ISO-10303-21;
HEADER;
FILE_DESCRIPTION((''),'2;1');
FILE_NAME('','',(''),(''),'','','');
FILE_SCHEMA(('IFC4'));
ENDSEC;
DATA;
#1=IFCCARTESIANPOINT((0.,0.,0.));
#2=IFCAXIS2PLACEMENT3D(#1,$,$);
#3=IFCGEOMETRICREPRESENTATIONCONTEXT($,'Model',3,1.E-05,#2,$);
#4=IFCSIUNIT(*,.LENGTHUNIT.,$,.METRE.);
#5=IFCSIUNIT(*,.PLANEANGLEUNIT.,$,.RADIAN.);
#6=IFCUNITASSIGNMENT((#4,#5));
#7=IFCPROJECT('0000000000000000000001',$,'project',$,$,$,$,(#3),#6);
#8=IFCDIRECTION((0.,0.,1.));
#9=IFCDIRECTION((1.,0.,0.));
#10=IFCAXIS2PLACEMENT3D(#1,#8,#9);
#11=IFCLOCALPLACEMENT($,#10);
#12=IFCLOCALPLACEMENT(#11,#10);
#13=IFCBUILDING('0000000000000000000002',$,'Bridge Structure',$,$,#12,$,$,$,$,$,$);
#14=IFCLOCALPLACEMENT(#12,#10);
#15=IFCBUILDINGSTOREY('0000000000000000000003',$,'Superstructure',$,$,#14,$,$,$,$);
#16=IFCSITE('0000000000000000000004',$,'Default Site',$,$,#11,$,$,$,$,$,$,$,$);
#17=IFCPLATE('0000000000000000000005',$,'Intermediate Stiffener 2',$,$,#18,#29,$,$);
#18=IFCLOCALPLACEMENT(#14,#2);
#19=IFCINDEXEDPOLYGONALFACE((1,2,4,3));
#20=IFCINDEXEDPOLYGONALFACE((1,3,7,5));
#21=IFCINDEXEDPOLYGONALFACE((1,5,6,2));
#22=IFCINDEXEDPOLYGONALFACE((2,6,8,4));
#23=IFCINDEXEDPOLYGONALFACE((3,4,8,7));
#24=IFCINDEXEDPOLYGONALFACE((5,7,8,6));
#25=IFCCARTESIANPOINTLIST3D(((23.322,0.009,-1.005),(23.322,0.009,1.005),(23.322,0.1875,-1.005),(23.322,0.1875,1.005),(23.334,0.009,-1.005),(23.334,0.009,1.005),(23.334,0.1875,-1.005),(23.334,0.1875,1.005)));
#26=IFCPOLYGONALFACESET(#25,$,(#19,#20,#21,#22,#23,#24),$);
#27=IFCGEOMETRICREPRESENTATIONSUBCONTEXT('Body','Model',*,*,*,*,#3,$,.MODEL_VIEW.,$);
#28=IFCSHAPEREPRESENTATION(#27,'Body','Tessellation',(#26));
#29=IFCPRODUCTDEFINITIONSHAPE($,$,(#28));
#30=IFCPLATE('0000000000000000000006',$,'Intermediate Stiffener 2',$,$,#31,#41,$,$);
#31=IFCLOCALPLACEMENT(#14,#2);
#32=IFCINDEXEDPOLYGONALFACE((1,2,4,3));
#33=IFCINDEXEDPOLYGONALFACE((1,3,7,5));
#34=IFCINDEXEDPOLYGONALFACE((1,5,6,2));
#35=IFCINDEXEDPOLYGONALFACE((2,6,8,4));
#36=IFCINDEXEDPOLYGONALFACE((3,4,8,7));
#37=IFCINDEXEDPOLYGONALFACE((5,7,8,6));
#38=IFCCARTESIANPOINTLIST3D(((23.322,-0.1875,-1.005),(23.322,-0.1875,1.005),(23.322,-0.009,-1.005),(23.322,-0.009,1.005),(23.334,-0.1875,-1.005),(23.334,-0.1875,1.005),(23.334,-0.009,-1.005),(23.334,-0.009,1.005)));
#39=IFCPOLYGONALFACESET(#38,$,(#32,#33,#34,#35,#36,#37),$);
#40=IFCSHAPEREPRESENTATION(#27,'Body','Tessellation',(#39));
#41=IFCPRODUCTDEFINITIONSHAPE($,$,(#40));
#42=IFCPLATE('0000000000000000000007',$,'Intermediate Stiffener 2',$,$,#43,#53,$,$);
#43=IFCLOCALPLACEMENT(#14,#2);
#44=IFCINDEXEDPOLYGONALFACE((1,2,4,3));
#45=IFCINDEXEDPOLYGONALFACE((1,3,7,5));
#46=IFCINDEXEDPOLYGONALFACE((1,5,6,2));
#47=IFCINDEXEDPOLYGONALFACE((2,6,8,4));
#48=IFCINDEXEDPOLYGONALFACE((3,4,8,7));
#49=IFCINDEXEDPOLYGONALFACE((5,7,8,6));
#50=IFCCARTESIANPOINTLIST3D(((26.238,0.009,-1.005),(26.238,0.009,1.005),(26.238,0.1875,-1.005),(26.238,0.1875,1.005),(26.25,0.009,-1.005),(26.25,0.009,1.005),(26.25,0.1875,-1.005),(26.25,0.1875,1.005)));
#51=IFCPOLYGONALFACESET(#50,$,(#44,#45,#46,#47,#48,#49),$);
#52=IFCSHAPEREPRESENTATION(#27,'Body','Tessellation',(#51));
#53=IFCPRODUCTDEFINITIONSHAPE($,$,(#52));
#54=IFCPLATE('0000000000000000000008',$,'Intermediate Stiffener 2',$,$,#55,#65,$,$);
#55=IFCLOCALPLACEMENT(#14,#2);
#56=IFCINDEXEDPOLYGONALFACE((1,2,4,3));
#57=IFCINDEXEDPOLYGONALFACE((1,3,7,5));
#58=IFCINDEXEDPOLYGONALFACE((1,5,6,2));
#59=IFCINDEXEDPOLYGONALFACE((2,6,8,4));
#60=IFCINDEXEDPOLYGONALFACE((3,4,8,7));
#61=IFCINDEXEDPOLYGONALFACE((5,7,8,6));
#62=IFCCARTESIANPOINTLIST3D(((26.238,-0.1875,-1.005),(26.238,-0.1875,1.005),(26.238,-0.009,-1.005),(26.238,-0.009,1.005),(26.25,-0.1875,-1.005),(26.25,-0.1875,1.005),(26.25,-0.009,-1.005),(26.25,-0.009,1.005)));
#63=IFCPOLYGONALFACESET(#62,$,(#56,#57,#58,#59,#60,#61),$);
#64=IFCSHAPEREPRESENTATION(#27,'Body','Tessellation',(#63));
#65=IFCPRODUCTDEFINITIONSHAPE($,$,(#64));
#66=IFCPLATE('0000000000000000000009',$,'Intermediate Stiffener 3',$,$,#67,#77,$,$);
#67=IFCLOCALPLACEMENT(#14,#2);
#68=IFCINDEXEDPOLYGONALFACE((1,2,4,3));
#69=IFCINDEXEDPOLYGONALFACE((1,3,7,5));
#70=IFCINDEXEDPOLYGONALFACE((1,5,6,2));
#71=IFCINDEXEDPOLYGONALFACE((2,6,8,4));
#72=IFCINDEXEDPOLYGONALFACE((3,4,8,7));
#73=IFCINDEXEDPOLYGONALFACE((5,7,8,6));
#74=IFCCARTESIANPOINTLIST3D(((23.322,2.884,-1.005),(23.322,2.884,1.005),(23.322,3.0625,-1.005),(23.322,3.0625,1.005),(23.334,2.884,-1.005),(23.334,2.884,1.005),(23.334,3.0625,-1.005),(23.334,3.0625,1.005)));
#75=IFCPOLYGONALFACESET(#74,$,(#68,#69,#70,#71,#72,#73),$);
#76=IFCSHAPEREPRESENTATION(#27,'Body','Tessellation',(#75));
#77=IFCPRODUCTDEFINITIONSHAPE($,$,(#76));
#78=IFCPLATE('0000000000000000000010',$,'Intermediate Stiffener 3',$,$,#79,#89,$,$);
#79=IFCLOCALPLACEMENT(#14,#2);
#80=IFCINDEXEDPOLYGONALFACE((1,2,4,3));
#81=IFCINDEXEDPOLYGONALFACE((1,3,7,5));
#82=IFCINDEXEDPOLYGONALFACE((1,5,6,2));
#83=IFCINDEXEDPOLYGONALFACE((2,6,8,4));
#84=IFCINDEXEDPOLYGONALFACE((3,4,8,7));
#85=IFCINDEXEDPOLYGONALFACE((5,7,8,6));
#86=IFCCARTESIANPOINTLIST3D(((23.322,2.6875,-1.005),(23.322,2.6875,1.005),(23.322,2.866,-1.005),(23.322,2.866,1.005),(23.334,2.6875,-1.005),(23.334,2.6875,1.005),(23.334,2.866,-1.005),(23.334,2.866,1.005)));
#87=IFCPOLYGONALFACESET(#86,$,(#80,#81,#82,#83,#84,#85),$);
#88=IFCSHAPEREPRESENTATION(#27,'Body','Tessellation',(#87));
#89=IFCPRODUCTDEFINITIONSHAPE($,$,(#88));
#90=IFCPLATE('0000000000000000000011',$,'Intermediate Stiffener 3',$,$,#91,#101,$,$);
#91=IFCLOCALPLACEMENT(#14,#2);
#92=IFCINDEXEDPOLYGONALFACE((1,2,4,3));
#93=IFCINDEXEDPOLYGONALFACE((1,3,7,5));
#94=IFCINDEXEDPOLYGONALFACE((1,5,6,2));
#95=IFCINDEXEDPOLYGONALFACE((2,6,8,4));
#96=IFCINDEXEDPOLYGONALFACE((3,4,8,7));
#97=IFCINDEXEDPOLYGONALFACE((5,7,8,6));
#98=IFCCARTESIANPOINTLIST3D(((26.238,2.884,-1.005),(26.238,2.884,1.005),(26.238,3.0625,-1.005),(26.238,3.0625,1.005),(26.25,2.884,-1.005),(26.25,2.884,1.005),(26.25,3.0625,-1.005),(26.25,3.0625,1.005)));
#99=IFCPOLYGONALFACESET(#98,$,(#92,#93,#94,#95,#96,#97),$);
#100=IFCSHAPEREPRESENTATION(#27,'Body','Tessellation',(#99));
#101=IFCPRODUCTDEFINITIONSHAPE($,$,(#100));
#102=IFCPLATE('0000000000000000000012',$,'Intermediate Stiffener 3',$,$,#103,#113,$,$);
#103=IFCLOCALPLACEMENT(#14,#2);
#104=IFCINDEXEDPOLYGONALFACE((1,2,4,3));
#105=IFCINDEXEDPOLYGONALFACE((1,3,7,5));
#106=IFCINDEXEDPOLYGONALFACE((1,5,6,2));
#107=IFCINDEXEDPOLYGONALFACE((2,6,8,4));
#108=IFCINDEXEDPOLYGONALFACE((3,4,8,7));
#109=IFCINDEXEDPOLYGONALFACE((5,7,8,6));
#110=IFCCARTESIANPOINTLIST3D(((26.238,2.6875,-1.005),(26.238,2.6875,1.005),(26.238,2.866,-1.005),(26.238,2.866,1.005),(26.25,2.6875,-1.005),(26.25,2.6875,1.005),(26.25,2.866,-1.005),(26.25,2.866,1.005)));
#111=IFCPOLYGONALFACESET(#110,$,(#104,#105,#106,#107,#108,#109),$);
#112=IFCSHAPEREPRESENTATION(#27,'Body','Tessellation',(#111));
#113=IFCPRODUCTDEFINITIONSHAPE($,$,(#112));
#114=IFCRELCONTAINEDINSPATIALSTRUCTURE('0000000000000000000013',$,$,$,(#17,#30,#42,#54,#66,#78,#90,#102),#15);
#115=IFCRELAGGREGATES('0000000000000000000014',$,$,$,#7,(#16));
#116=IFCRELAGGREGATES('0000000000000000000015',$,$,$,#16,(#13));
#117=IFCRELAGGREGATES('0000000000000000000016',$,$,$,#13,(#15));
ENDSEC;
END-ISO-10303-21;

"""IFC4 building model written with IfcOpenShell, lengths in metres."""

from ifc_helpers import new_model, si_unit, frame, origin, origin_with_axes, origin_2d_with_axis, place, context, subcontext, project, spatial, rectangle, extrude, element, save


model = new_model("IFC4")

# Units and contexts
model_context = context("Model", 3, precision=1e-05, world=origin())
body_context = subcontext(model_context, "Body", "Model", "MODEL_VIEW")
ifc_project = project(units=[si_unit("LENGTHUNIT", "METRE"), si_unit("PLANEANGLEUNIT", "RADIAN")], contexts=[model_context])

# Site, building, storey
site_placement = place(None, origin_with_axes())
site = spatial("IfcSite", under=ifc_project, at=site_placement, Name="Default Site")
building_placement = place(site_placement, origin_with_axes())
building = spatial("IfcBuilding", under=site, at=building_placement, Name="Bridge Structure")
storey_placement = place(building_placement, origin_with_axes())
storey = spatial("IfcBuildingStorey", under=building, at=storey_placement, Name="Superstructure")

# Plates
for number, where, z_axis, x_axis, name in (
    (1, (23.328, 0.0983, -1.005), (0.0, 0.0, 1.0), (1.0, 0.0, 0.0), "Intermediate Stiffener 2"),
    (2, (23.328, -0.0983, -1.005), (0.0, 0.0, 1.0), (1.0, 0.0, 0.0), "Intermediate Stiffener 2"),
    (3, (26.244, 0.0983, -1.005), (0.0, 0.0, 1.0), (1.0, 0.0, 0.0), "Intermediate Stiffener 2"),
    (4, (26.244, -0.0983, -1.005), (0.0, 0.0, 1.0), (1.0, 0.0, 0.0), "Intermediate Stiffener 2"),
    (5, (23.328, 2.9733, -1.005), (0.0, 0.0, 1.0), (1.0, 0.0, 0.0), "Intermediate Stiffener 3"),
    (6, (23.328, 2.7768, -1.005), (0.0, 0.0, 1.0), (1.0, 0.0, 0.0), "Intermediate Stiffener 3"),
    (7, (26.244, 2.9733, -1.005), (0.0, 0.0, 1.0), (1.0, 0.0, 0.0), "Intermediate Stiffener 3"),
    (8, (26.244, 2.7768, -1.005), (0.0, 0.0, 1.0), (1.0, 0.0, 0.0), "Intermediate Stiffener 3"),
):
    element("IfcPlate", number, at=place(storey_placement, frame(where, z_axis=z_axis, x_axis=x_axis)), inside=storey, Name=name, context=body_context, shape_type="SweptSolid", body=[
        extrude(rectangle(XDim=0.012, YDim=0.1785, at=origin_2d_with_axis()), origin_with_axes(), (0.0, 0.0, 1.0), 2.01),
    ])

save(model, "model.ifc")
